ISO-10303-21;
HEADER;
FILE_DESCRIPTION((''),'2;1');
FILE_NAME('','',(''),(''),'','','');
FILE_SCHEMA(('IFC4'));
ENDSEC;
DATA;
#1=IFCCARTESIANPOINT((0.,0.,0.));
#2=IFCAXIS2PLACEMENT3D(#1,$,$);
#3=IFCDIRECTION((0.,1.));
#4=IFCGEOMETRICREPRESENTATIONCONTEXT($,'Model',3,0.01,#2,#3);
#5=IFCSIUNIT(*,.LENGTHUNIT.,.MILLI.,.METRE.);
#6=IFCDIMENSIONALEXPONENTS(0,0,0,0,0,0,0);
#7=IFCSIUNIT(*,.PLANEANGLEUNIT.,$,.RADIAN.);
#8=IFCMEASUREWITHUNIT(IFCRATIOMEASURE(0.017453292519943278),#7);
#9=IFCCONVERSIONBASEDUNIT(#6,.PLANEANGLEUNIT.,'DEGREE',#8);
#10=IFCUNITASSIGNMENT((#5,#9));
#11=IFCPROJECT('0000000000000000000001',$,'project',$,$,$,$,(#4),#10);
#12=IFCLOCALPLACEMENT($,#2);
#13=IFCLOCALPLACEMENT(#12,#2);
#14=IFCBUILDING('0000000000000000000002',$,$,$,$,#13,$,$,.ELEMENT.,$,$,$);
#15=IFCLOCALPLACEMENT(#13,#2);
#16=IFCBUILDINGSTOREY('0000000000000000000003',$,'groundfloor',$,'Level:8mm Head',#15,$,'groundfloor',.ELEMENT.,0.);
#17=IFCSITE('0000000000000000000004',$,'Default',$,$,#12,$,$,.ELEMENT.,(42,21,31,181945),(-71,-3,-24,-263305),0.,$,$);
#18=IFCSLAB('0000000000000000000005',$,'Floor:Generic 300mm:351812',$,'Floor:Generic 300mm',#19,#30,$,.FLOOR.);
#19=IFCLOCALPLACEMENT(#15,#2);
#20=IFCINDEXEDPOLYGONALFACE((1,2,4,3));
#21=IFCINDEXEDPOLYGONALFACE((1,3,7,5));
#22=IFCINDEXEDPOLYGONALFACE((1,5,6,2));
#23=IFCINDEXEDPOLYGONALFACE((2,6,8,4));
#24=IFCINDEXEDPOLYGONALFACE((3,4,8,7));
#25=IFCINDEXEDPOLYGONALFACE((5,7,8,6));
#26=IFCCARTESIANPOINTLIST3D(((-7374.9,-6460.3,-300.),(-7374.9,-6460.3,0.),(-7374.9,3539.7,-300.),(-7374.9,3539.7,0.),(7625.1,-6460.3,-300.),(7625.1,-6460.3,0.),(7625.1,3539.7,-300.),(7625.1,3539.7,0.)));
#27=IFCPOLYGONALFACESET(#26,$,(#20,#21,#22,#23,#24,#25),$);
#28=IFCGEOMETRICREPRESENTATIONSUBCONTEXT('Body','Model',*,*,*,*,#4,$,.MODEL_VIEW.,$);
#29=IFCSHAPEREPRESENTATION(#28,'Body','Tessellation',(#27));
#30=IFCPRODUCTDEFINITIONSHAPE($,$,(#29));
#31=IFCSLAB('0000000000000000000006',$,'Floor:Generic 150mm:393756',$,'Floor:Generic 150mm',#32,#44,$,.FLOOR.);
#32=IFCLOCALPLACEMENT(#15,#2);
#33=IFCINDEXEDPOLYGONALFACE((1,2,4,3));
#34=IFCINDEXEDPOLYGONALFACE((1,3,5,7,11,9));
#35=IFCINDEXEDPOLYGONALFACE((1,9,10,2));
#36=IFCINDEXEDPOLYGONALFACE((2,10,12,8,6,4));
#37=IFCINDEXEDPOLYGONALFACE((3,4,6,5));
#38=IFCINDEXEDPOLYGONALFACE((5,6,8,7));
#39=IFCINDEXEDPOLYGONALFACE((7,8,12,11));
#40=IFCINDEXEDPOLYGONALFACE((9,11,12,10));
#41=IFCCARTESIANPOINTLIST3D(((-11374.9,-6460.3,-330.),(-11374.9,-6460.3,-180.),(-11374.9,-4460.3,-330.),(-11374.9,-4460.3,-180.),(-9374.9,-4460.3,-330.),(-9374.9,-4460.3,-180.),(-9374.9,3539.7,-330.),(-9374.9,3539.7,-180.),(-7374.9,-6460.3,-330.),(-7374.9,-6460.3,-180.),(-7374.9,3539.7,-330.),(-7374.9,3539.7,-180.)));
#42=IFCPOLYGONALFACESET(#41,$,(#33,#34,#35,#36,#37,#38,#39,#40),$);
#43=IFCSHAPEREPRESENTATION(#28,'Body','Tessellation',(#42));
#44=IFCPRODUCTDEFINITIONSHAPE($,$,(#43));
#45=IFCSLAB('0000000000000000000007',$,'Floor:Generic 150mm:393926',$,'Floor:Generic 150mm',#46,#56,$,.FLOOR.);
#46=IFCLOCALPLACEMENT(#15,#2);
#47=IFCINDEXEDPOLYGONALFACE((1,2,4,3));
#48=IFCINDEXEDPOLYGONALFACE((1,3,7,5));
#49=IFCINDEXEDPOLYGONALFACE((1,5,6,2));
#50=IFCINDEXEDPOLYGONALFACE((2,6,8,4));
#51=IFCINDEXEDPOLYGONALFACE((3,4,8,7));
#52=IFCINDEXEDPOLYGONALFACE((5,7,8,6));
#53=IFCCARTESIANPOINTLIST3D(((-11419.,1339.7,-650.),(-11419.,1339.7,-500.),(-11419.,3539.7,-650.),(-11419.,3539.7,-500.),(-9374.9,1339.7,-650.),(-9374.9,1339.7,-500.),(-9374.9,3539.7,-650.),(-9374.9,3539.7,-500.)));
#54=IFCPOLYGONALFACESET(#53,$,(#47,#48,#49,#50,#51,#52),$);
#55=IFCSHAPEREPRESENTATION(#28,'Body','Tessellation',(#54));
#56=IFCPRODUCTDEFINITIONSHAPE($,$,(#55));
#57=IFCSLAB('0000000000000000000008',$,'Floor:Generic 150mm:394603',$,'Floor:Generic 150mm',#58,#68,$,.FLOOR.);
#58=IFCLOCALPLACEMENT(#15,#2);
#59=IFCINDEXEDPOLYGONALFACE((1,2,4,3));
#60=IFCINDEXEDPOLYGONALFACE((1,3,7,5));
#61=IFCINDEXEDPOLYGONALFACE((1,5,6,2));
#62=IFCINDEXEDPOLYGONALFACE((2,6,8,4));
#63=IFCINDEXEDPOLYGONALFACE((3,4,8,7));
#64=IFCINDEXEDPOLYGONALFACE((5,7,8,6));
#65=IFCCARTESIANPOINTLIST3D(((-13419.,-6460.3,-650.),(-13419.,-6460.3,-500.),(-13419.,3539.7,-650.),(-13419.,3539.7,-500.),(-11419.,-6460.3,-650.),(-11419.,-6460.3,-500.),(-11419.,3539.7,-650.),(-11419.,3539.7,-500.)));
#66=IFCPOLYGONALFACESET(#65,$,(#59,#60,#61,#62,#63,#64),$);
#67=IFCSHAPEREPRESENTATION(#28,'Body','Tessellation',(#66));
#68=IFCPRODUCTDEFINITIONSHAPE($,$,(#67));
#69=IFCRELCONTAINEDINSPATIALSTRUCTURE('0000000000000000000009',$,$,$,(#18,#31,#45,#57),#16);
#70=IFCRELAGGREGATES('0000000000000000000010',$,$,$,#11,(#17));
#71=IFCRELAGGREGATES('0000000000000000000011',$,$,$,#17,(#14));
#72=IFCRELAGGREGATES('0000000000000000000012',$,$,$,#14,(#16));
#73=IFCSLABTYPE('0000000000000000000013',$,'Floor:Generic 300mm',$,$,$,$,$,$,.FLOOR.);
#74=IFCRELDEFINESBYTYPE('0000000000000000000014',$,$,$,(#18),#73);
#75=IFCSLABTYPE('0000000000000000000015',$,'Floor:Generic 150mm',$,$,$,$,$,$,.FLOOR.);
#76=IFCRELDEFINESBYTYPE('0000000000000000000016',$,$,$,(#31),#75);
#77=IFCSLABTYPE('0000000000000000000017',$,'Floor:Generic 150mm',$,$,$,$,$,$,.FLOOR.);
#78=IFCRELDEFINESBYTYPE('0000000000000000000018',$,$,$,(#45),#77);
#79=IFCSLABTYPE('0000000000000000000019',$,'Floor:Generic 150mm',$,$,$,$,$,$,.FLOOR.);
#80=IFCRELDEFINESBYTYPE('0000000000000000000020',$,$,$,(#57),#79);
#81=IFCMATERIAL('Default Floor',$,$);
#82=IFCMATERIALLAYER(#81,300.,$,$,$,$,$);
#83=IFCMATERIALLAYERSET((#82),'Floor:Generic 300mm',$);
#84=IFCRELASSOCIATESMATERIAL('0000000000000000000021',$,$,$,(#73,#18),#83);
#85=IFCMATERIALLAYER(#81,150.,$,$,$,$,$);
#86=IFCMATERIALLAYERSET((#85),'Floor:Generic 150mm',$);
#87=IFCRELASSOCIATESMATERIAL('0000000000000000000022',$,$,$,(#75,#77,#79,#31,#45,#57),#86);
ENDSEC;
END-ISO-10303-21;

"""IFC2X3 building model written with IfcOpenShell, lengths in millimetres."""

from ifc_helpers import new_model, entity, si_unit, converted_unit, direction, frame, frame_2d, origin, origin_2d_with_axis, place, context, subcontext, project, spatial, polyline, rectangle, outline, extrude, material, layer, layer_set, layer_usage, type_object, element, save


model = new_model("IFC2X3")

# Units and contexts
model_context = context("Model", 3, precision=0.01, world=origin(), true_north=direction((0.0, 1.0)))
body_context = subcontext(model_context, "Body", "Model", "MODEL_VIEW")
ifc_project = project(units=[si_unit("LENGTHUNIT", "METRE", prefix="MILLI"), converted_unit("PLANEANGLEUNIT", "DEGREE", entity("IfcRatioMeasure", 0.017453292519943278), si_unit("PLANEANGLEUNIT", "RADIAN"), dimensions=[0, 0, 0, 0, 0, 0, 0])], contexts=[model_context])

# Site, building, storey
site_placement = place(None, origin())
site = spatial("IfcSite", under=ifc_project, at=site_placement, Name="Default", CompositionType="ELEMENT", RefLatitude=(42, 21, 31, 181945), RefLongitude=(-71, -3, -24, -263305), RefElevation=0.0)
building_placement = place(site_placement, origin())
building = spatial("IfcBuilding", under=site, at=building_placement, CompositionType="ELEMENT")
storey_placement = place(building_placement, origin())
storey = spatial("IfcBuildingStorey", under=building, at=storey_placement, Name="groundfloor", ObjectType="Level:8mm Head", LongName="groundfloor", CompositionType="ELEMENT", Elevation=0.0)

# Slabs
ifc_material_1 = material(Name="Default Floor")
ifc_layer_1 = layer(ifc_material_1, 300.0)
ifc_layer_set_1 = layer_set([ifc_layer_1], Name="Floor:Generic 300mm")
ifc_layer_usage_1 = layer_usage(ifc_layer_set_1, "AXIS3", "POSITIVE", 0.0)
slab_type_1 = type_object("IfcSlabType", Name="Floor:Generic 300mm", PredefinedType="FLOOR", material=ifc_layer_set_1)
slab_1_placement = place(storey_placement, origin())
element("IfcSlab", 1, at=slab_1_placement, inside=storey, type_object=slab_type_1, material=ifc_layer_usage_1, Name="Floor:Generic 300mm:351812", ObjectType="Floor:Generic 300mm", PredefinedType="FLOOR", context=body_context, shape_type="SweptSolid", body=[
    extrude(rectangle(XDim=10000.0, YDim=15000.0, at=origin_2d_with_axis()), frame((125.1, -1460.3, 0.0), z_axis=(0.0, 0.0, -1.0), x_axis=(0.0, 1.0, 0.0)), (0.0, 0.0, 1.0), 300.0),
])
ifc_layer_2 = layer(ifc_material_1, 150.0)
ifc_layer_set_2 = layer_set([ifc_layer_2], Name="Floor:Generic 150mm")
ifc_layer_usage_2 = layer_usage(ifc_layer_set_2, "AXIS3", "POSITIVE", 0.0)
slab_type_2 = type_object("IfcSlabType", Name="Floor:Generic 150mm", PredefinedType="FLOOR", material=ifc_layer_set_2)
slab_2_placement = place(storey_placement, origin())
element("IfcSlab", 2, at=slab_2_placement, inside=storey, type_object=slab_type_2, material=ifc_layer_usage_2, Name="Floor:Generic 150mm:393756", ObjectType="Floor:Generic 150mm", PredefinedType="FLOOR", context=body_context, shape_type="SweptSolid", body=[
    extrude(outline(polyline([(-4000.0, -2000.0), (-2000.0, -2000.0), (-2000.0, 0.0), (6000.0, 0.0), (6000.0, 2000.0), (-4000.0, 2000.0), (-4000.0, -2000.0)])), frame((-9374.9, -2460.3, -180.0), z_axis=(0.0, 0.0, -1.0), x_axis=(0.0, 1.0, 0.0)), (0.0, 0.0, 1.0), 150.0),
])
ifc_layer_usage_3 = layer_usage(ifc_layer_set_2, "AXIS3", "POSITIVE", 0.0)
slab_type_3 = type_object("IfcSlabType", Name="Floor:Generic 150mm", PredefinedType="FLOOR", material=ifc_layer_set_2)
slab_3_placement = place(storey_placement, origin())
element("IfcSlab", 3, at=slab_3_placement, inside=storey, type_object=slab_type_3, material=ifc_layer_usage_3, Name="Floor:Generic 150mm:393926", ObjectType="Floor:Generic 150mm", PredefinedType="FLOOR", context=body_context, shape_type="SweptSolid", body=[
    extrude(rectangle(XDim=2200.0, YDim=2044.0, at=frame_2d((0.0, 0.0), x_axis=(1.0, 0.0))), frame((-10397.0, 2439.7, -500.0), z_axis=(0.0, 0.0, -1.0), x_axis=(0.0, 1.0, 0.0)), (0.0, 0.0, 1.0), 150.0),
])
ifc_layer_usage_4 = layer_usage(ifc_layer_set_2, "AXIS3", "POSITIVE", 0.0)
slab_type_4 = type_object("IfcSlabType", Name="Floor:Generic 150mm", PredefinedType="FLOOR", material=ifc_layer_set_2)
slab_4_placement = place(storey_placement, origin())
element("IfcSlab", 4, at=slab_4_placement, inside=storey, type_object=slab_type_4, material=ifc_layer_usage_4, Name="Floor:Generic 150mm:394603", ObjectType="Floor:Generic 150mm", PredefinedType="FLOOR", context=body_context, shape_type="SweptSolid", body=[
    extrude(rectangle(XDim=10000.0, YDim=2000.0, at=frame_2d((0.0, 0.0), x_axis=(1.0, 0.0))), frame((-12419.0, -1460.3, -500.0), z_axis=(0.0, 0.0, -1.0), x_axis=(0.0, 1.0, 0.0)), (0.0, 0.0, 1.0), 150.0),
])

save(model, "model.ifc")
